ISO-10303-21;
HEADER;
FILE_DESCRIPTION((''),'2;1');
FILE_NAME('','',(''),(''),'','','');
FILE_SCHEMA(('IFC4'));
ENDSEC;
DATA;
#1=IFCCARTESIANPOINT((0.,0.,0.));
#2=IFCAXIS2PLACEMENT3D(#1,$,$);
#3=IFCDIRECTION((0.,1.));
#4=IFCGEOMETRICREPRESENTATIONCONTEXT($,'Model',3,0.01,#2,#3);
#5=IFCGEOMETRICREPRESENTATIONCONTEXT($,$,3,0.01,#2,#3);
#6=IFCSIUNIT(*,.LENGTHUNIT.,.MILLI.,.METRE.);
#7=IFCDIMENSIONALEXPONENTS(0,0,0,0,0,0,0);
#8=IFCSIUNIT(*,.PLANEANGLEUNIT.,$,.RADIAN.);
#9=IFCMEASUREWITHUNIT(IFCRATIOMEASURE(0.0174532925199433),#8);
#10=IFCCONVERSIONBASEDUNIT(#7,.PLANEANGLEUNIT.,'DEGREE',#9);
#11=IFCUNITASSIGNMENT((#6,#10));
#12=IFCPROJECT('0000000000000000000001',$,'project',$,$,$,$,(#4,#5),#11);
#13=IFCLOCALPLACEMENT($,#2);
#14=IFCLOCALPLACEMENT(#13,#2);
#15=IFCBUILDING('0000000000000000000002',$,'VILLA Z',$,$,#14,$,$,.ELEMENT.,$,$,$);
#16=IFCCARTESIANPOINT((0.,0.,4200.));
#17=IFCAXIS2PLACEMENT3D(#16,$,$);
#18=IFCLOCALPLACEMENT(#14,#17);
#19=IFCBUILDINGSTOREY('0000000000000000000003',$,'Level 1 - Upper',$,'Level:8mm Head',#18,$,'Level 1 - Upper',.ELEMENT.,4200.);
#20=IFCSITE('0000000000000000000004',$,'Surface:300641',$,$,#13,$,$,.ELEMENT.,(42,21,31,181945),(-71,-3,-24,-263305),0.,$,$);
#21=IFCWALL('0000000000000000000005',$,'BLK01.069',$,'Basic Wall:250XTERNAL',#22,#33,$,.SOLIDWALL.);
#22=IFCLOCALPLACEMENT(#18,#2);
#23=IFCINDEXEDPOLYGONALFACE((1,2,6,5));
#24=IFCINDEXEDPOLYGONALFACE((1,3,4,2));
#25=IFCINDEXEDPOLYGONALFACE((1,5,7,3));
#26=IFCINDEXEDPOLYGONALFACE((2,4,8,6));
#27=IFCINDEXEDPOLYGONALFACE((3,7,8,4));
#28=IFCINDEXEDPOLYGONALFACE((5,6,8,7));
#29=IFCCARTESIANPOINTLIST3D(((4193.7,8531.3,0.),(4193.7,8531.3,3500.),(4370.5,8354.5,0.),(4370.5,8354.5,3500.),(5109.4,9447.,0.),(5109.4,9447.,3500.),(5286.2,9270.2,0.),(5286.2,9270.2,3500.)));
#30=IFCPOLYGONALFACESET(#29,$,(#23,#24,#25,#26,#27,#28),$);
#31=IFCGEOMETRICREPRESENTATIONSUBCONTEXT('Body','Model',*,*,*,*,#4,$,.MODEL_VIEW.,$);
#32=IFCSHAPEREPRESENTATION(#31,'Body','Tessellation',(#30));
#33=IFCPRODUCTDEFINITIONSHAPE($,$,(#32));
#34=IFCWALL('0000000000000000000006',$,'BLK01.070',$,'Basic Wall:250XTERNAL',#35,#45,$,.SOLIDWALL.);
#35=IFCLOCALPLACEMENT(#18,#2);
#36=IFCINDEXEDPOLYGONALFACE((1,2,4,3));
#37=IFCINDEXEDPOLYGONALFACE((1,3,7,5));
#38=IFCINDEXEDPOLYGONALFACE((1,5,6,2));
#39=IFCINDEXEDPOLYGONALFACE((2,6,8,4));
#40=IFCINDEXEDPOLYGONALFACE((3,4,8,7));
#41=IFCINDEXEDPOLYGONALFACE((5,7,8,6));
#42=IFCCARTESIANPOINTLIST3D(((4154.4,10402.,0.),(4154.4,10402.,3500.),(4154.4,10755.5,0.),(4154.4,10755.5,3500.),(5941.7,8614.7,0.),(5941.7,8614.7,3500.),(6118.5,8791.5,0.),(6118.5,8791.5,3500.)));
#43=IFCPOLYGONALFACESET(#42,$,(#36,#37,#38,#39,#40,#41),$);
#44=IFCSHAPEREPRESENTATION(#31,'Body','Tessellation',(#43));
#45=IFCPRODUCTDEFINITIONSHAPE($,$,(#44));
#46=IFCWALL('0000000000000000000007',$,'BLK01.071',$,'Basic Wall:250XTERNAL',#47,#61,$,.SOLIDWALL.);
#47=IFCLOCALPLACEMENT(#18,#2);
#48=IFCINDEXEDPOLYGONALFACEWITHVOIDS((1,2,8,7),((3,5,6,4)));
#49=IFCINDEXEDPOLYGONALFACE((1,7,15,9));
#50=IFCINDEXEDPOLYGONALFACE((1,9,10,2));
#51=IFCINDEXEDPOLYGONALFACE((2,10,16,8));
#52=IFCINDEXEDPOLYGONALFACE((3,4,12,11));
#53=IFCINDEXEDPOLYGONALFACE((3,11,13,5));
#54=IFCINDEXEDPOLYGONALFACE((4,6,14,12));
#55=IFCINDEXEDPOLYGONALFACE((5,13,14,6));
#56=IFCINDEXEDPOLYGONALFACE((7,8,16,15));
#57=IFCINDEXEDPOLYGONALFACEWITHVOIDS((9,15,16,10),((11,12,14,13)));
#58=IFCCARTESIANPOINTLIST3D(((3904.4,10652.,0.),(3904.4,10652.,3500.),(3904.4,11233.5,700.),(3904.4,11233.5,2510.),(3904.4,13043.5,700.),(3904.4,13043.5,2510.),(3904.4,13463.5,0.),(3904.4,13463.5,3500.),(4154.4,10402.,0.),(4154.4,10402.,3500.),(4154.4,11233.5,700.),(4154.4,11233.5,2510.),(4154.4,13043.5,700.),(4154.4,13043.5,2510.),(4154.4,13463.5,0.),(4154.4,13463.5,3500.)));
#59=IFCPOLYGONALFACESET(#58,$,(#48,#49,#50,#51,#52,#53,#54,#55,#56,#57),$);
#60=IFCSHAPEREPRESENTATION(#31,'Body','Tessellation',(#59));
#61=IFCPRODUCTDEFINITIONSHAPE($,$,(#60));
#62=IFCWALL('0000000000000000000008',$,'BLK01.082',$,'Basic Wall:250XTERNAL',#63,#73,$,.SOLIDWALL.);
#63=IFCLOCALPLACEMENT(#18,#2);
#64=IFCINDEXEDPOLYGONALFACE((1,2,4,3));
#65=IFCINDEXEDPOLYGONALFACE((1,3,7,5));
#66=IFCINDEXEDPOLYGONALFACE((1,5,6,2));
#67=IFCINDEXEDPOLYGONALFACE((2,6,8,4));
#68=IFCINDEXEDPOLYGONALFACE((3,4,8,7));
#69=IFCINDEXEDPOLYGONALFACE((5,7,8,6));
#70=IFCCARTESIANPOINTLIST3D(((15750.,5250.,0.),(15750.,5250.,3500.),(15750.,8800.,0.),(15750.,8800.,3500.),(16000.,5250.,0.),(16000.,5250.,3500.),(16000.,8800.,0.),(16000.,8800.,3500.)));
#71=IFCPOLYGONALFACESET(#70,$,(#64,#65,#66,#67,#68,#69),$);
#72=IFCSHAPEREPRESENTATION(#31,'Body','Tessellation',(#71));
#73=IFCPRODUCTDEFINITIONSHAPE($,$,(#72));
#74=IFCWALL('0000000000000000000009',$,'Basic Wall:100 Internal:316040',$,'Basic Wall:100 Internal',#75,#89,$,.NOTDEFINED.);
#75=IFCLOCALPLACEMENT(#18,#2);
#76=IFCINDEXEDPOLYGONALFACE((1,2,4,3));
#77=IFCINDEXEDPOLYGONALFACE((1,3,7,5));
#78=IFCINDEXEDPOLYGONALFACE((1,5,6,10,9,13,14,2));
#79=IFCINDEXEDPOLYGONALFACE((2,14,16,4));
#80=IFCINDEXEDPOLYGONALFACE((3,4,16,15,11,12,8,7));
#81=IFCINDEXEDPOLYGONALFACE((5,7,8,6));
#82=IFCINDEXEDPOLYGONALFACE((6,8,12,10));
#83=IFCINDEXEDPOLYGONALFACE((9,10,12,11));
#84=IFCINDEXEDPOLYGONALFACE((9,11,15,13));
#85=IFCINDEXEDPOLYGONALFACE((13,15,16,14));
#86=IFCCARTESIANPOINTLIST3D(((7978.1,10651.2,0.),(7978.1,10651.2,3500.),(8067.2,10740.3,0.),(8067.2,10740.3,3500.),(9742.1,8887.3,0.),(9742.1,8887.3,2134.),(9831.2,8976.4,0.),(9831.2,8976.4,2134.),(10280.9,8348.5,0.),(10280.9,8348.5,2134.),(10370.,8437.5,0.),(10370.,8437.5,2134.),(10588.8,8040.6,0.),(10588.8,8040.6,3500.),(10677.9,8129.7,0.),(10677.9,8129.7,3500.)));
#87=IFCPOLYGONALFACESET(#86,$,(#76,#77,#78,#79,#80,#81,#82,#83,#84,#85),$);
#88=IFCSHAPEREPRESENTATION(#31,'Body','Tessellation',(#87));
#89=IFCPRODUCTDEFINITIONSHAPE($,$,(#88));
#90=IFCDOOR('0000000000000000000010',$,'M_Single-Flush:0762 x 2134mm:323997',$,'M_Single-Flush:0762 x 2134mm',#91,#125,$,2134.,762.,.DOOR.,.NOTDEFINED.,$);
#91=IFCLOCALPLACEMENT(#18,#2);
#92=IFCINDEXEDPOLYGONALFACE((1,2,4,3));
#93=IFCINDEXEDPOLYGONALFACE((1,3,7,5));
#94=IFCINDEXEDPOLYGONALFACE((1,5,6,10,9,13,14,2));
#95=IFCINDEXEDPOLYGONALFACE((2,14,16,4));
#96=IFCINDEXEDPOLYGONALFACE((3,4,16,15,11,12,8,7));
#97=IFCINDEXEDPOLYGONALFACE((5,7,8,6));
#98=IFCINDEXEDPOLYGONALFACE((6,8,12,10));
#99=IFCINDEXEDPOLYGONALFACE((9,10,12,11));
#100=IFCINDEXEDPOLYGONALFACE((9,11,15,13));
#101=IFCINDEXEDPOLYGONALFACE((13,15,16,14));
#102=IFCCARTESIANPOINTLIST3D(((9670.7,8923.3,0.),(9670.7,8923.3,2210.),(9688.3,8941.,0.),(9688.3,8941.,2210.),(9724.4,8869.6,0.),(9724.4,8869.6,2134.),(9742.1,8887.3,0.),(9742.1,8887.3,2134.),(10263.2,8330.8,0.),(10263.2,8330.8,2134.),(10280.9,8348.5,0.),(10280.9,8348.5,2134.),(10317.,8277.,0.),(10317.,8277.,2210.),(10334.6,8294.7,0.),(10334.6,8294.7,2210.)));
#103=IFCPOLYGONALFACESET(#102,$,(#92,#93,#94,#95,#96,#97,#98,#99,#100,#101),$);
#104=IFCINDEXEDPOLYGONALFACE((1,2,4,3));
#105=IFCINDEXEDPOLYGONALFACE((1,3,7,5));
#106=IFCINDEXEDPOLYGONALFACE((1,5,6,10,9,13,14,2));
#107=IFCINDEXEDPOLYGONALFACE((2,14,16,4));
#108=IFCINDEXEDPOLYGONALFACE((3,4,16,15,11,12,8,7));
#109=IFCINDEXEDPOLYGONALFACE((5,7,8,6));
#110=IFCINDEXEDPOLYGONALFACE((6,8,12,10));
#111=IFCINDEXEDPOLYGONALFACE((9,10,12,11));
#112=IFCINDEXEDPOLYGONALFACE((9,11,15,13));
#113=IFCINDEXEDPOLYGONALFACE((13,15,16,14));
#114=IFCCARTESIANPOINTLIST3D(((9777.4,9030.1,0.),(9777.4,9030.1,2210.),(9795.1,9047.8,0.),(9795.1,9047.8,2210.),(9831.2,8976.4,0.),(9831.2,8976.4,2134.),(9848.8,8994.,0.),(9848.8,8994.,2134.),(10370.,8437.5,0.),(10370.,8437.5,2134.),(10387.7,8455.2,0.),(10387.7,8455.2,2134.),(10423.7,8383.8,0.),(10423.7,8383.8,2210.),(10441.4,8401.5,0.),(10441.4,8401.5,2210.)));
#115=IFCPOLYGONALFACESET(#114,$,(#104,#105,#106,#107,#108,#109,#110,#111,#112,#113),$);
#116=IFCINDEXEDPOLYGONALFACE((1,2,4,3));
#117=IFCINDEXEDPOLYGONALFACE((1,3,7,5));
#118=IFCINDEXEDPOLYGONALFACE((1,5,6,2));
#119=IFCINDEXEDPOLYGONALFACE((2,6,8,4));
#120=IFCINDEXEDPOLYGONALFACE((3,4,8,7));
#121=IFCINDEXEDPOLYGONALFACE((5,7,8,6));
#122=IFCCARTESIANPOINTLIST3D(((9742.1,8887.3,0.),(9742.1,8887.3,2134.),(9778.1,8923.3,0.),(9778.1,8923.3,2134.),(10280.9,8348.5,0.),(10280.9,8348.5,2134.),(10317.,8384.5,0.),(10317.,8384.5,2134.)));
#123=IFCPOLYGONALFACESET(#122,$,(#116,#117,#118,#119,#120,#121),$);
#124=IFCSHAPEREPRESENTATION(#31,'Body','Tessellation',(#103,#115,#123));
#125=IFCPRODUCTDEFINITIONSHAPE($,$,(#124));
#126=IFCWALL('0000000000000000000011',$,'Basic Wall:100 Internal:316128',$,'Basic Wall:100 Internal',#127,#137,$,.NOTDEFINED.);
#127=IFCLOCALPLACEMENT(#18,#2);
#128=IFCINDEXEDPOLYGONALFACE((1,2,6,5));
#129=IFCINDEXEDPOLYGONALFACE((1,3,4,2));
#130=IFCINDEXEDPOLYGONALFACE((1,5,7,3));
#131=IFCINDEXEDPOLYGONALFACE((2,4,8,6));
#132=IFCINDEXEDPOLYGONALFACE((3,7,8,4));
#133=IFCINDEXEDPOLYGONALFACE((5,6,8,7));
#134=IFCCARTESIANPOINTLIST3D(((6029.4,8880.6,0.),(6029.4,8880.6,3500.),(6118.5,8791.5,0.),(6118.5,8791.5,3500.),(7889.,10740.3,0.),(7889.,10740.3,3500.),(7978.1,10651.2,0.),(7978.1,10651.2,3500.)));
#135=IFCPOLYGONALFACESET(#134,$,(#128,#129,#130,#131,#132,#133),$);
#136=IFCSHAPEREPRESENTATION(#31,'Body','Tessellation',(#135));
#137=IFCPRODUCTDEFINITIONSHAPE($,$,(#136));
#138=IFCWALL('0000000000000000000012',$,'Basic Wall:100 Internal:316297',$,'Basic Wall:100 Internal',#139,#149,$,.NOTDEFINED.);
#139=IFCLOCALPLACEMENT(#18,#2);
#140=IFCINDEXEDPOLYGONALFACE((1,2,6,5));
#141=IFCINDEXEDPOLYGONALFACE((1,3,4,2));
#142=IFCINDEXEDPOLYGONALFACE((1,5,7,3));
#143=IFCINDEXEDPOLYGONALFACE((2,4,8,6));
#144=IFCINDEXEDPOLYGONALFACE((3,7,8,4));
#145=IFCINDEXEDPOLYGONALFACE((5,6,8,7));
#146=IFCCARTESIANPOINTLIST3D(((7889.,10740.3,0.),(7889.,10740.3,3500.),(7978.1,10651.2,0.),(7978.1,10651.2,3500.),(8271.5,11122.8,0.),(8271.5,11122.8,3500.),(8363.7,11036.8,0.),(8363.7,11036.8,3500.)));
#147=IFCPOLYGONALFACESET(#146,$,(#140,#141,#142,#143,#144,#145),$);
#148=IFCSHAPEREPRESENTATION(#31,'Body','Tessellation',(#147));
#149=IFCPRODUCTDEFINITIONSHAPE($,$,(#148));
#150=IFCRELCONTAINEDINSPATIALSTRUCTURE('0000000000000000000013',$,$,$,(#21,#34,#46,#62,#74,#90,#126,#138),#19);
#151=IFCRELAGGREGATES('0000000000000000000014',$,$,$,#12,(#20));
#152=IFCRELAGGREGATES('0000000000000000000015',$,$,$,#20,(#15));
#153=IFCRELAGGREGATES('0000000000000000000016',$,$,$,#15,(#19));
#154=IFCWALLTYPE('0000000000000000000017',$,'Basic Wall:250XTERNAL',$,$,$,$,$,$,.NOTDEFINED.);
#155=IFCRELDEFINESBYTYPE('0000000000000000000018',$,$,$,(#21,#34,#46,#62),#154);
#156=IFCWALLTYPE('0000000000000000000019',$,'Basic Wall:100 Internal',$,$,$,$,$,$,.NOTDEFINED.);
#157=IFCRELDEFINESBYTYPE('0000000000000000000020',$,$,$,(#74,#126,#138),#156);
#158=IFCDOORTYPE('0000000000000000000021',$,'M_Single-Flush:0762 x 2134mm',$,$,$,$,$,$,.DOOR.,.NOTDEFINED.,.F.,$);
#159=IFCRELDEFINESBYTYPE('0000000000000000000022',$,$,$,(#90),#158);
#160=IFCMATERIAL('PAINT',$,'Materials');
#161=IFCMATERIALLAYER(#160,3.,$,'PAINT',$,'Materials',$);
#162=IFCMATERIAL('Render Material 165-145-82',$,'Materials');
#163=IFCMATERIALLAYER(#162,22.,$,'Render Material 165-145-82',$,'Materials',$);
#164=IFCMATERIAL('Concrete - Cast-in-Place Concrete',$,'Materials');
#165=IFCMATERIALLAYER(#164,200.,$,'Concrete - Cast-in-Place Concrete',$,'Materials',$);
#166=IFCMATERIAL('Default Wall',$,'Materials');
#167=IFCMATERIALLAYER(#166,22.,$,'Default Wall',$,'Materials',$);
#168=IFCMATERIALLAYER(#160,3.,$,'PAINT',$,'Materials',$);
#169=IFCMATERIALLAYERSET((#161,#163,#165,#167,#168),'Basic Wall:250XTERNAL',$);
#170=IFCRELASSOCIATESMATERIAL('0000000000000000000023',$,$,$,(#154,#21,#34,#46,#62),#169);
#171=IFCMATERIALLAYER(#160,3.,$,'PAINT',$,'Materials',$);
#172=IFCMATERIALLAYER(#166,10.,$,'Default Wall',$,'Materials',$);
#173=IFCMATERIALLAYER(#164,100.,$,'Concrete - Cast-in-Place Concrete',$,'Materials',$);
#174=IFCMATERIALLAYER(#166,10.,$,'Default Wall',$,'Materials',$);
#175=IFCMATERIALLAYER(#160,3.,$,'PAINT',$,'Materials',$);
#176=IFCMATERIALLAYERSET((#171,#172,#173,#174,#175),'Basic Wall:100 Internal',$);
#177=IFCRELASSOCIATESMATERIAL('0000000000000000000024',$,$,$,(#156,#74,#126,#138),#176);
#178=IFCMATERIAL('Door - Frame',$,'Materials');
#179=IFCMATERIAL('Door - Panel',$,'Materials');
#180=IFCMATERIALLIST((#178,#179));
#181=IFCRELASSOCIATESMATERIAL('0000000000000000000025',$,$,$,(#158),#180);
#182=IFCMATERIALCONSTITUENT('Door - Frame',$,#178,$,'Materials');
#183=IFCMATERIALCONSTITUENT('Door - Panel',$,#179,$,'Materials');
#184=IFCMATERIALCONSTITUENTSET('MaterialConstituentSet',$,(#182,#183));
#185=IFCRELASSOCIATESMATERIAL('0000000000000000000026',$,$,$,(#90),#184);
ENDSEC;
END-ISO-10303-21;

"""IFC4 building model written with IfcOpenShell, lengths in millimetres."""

from ifc_helpers import new_model, entity, si_unit, converted_unit, direction, frame, frame_2d, origin, place, context, subcontext, project, spatial, polyline, rectangle, outline, extrude, clip, halfspace, source, transform, mapped, material, material_list, layer, layer_set, layer_usage, constituent, constituent_set, type_object, type_shapes, element, fill, save


model = new_model("IFC4")

# Units and contexts
model_context = context("Model", 3, precision=0.01, world=origin(), true_north=direction((0.0, 1.0)))
context_of_model = context(None, 3, precision=0.01, world=origin(), true_north=direction((0.0, 1.0)))
body_context = subcontext(model_context, "Body", "Model", "MODEL_VIEW")
ifc_project = project(units=[si_unit("LENGTHUNIT", "METRE", prefix="MILLI"), converted_unit("PLANEANGLEUNIT", "DEGREE", entity("IfcRatioMeasure", 0.0174532925199433), si_unit("PLANEANGLEUNIT", "RADIAN"), dimensions=[0, 0, 0, 0, 0, 0, 0])], contexts=[model_context, context_of_model])

# Site, building, storey
site_placement = place(None, origin())
site = spatial("IfcSite", under=ifc_project, at=site_placement, Name="Surface:300641", CompositionType="ELEMENT", RefLatitude=(42, 21, 31, 181945), RefLongitude=(-71, -3, -24, -263305), RefElevation=0.0)
building_placement = place(site_placement, origin())
building = spatial("IfcBuilding", under=site, at=building_placement, Name="VILLA Z", CompositionType="ELEMENT")
storey_placement = place(building_placement, frame((0.0, 0.0, 4200.0)))
storey = spatial("IfcBuildingStorey", under=building, at=storey_placement, Name="Level 1 - Upper", ObjectType="Level:8mm Head", LongName="Level 1 - Upper", CompositionType="ELEMENT", Elevation=4200.0)

# Shared definitions
ifc_material_1 = material(Name="PAINT", Category="Materials")
ifc_layer_1 = layer(ifc_material_1, 3.0, Name="PAINT", Category="Materials")
ifc_material_2 = material(Name="Render Material 165-145-82", Category="Materials")
ifc_layer_2 = layer(ifc_material_2, 22.0, Name="Render Material 165-145-82", Category="Materials")
ifc_material_3 = material(Name="Concrete - Cast-in-Place Concrete", Category="Materials")
ifc_layer_3 = layer(ifc_material_3, 200.0, Name="Concrete - Cast-in-Place Concrete", Category="Materials")
ifc_material_4 = material(Name="Default Wall", Category="Materials")
ifc_layer_4 = layer(ifc_material_4, 22.0, Name="Default Wall", Category="Materials")
ifc_layer_5 = layer(ifc_material_1, 3.0, Name="PAINT", Category="Materials")
ifc_layer_set_1 = layer_set([ifc_layer_1, ifc_layer_2, ifc_layer_3, ifc_layer_4, ifc_layer_5], Name="Basic Wall:250XTERNAL")
wall_type_1 = type_object("IfcWallType", Name="Basic Wall:250XTERNAL", PredefinedType="NOTDEFINED", material=ifc_layer_set_1)

# Walls
ifc_layer_usage_1 = layer_usage(ifc_layer_set_1, "AXIS2", "NEGATIVE", 125.0)
wall_1_placement = place(storey_placement, frame((4282.1, 8442.9, 0.0), z_axis=(0.0, 0.0, 1.0), x_axis=(0.707107, 0.707107, 0.0)))
element("IfcWall", 1, at=wall_1_placement, inside=storey, type_object=wall_type_1, material=ifc_layer_usage_1, Name="BLK01.069", ObjectType="Basic Wall:250XTERNAL", PredefinedType="SOLIDWALL", context=body_context, shape_type="Clipping", body=[
    clip(extrude(rectangle(XDim=1295.0, YDim=250.0, at=frame_2d((647.5, 0.0), x_axis=(-1.0, 0.0))), origin(), (0.0, 0.0, 1.0), 3500.0), halfspace(origin(), True)),
])
ifc_layer_usage_2 = layer_usage(ifc_layer_set_1, "AXIS2", "NEGATIVE", 125.0)
wall_2_placement = place(storey_placement, frame((6030.1, 8703.1, 0.0), z_axis=(0.0, 0.0, 1.0), x_axis=(-0.707107, 0.707107, 0.0)))
element("IfcWall", 2, at=wall_2_placement, inside=storey, type_object=wall_type_1, material=ifc_layer_usage_2, Name="BLK01.070", ObjectType="Basic Wall:250XTERNAL", PredefinedType="SOLIDWALL", context=body_context, shape_type="Clipping", body=[
    clip(extrude(outline(polyline([(2777.5, -125.0), (2527.5, 125.0), (1177.0, 125.0), (927.0, 125.0), (0.0, 125.0), (0.0, -125.0), (126.0, -125.0), (2777.5, -125.0)])), origin(), (0.0, 0.0, 1.0), 3500.0), halfspace(origin(), True)),
])

# Wall, opening
ifc_layer_usage_3 = layer_usage(ifc_layer_set_1, "AXIS2", "NEGATIVE", 125.0)
wall_3_placement = place(storey_placement, frame((4029.4, 10402.0, 0.0), z_axis=(0.0, 0.0, 1.0), x_axis=(0.0, 1.0, 0.0)))
wall_3 = element("IfcWall", 3, at=wall_3_placement, inside=storey, type_object=wall_type_1, material=ifc_layer_usage_3, Name="BLK01.071", ObjectType="Basic Wall:250XTERNAL", PredefinedType="SOLIDWALL", context=body_context, shape_type="Clipping", body=[
    clip(extrude(outline(polyline([(3061.5, -125.0), (3061.5, 125.0), (250.0, 125.0), (0.0, -125.0), (353.6, -125.0), (2811.5, -125.0), (3061.5, -125.0)])), origin(), (0.0, 0.0, 1.0), 3500.0), halfspace(origin(), True)),
])
opening_1_placement = place(wall_3_placement, frame((831.5, -125.0, 700.0)))
element("IfcOpeningElement", 4, at=opening_1_placement, cuts=wall_3, ObjectType="Opening", PredefinedType="OPENING", context=body_context, shape_type="SweptSolid", body=[
    extrude(rectangle(XDim=1810.0, YDim=1810.0, at=frame_2d((905.0, 905.0), x_axis=(-1.0, 0.0))), frame((0.0, 0.0, 0.0), z_axis=(0.0, 1.0, 0.0), x_axis=(0.0, 0.0, 1.0)), (0.0, 0.0, 1.0), 250.0),
])

# Wall
ifc_layer_usage_4 = layer_usage(ifc_layer_set_1, "AXIS2", "POSITIVE", -125.0)
wall_4_placement = place(storey_placement, frame((15875.0, 5250.0, 0.0), z_axis=(0.0, 0.0, 1.0), x_axis=(0.0, 1.0, 0.0)))
element("IfcWall", 5, at=wall_4_placement, inside=storey, type_object=wall_type_1, material=ifc_layer_usage_4, Name="BLK01.082", ObjectType="Basic Wall:250XTERNAL", PredefinedType="SOLIDWALL", context=body_context, shape_type="Clipping", body=[
    clip(extrude(rectangle(XDim=3550.0, YDim=250.0, at=frame_2d((1775.0, 0.0), x_axis=(-1.0, 0.0))), origin(), (0.0, 0.0, 1.0), 3500.0), halfspace(origin(), True)),
])
ifc_layer_6 = layer(ifc_material_1, 3.0, Name="PAINT", Category="Materials")
ifc_layer_7 = layer(ifc_material_4, 10.0, Name="Default Wall", Category="Materials")
ifc_layer_8 = layer(ifc_material_3, 100.0, Name="Concrete - Cast-in-Place Concrete", Category="Materials")
ifc_layer_9 = layer(ifc_material_4, 10.0, Name="Default Wall", Category="Materials")
ifc_layer_10 = layer(ifc_material_1, 3.0, Name="PAINT", Category="Materials")
ifc_layer_set_2 = layer_set([ifc_layer_6, ifc_layer_7, ifc_layer_8, ifc_layer_9, ifc_layer_10], Name="Basic Wall:100 Internal")
wall_type_2 = type_object("IfcWallType", Name="Basic Wall:100 Internal", PredefinedType="NOTDEFINED", material=ifc_layer_set_2)

# Wall, opening, door
ifc_layer_usage_5 = layer_usage(ifc_layer_set_2, "AXIS2", "POSITIVE", -63.0)
wall_5_placement = place(storey_placement, frame((8022.7, 10695.7, 0.0), z_axis=(0.0, 0.0, 1.0), x_axis=(0.707107, -0.707107, 0.0)))
wall_5 = element("IfcWall", 6, at=wall_5_placement, inside=storey, type_object=wall_type_2, material=ifc_layer_usage_5, Name="Basic Wall:100 Internal:316040", ObjectType="Basic Wall:100 Internal", PredefinedType="NOTDEFINED", context=body_context, shape_type="Clipping", body=[
    clip(extrude(rectangle(XDim=3692.0, YDim=126.0, at=frame_2d((1846.0, 0.0), x_axis=(-1.0, 0.0))), origin(), (0.0, 0.0, 1.0), 3500.0), halfspace(origin(), True)),
])
opening_2_placement = place(wall_5_placement, frame((3256.6, 63.0, 0.0)))
opening_2 = element("IfcOpeningElement", 7, at=opening_2_placement, cuts=wall_5, ObjectType="Opening", PredefinedType="OPENING", context=body_context, shape_type="SweptSolid", body=[
    extrude(rectangle(XDim=762.0, YDim=2134.0, at=frame_2d((1067.0, 381.0), x_axis=(0.0, -1.0))), frame((0.0, 0.0, 0.0), z_axis=(0.0, -1.0, 0.0), x_axis=(0.0, 0.0, 1.0)), (0.0, 0.0, 1.0), 126.0),
])
ifc_material_5 = material(Name="Door - Frame", Category="Materials")
ifc_constituent_1 = constituent(ifc_material_5, Name="Door - Frame", Category="Materials")
ifc_material_6 = material(Name="Door - Panel", Category="Materials")
ifc_constituent_2 = constituent(ifc_material_6, Name="Door - Panel", Category="Materials")
ifc_constituent_set_1 = constituent_set(constituents=[ifc_constituent_1, ifc_constituent_2], Name="MaterialConstituentSet")
ifc_material_list = material_list([ifc_material_5, ifc_material_6])
door_type = type_object("IfcDoorType", Name="M_Single-Flush:0762 x 2134mm", OperationType="NOTDEFINED", ParameterTakesPrecedence=False, PredefinedType="DOOR", material=ifc_material_list)
shared_shape_1 = source(origin(), body_context, "Body", "SweptSolid", [
    extrude(outline(polyline([(-457.0, -1124.0), (457.0, -1124.0), (457.0, 1086.0), (381.0, 1086.0), (381.0, -1048.0), (-381.0, -1048.0), (-381.0, 1086.0), (-457.0, 1086.0), (-457.0, -1124.0)])), frame((381.0, 151.0, 1086.0), z_axis=(0.0, -1.0, 0.0), x_axis=(-1.0, 0.0, 0.0)), (0.0, 0.0, 1.0), 25.0),
    extrude(outline(polyline([(-1124.0, -457.0), (1086.0, -457.0), (1086.0, -381.0), (-1048.0, -381.0), (-1048.0, 381.0), (1086.0, 381.0), (1086.0, 457.0), (-1124.0, 457.0), (-1124.0, -457.0)])), frame((381.0, 0.0, 1086.0), z_axis=(0.0, -1.0, 0.0), x_axis=(0.0, 0.0, -1.0)), (0.0, 0.0, 1.0), 25.0),
    extrude(rectangle(XDim=762.0, YDim=51.0, at=frame_2d((0.0, 0.0), x_axis=(1.0, 0.0))), frame((381.0, 100.5, 0.0)), (0.0, 0.0, 1.0), 2134.0),
])
type_shapes(door_type, [shared_shape_1])
door_1_placement = place(opening_2_placement, frame((0.0, 0.0, 0.0), z_axis=(0.0, 0.0, 1.0), x_axis=(-1.0, 0.0, 0.0)))
door_1 = element("IfcDoor", 8, at=door_1_placement, inside=storey, type_object=door_type, material=ifc_constituent_set_1, Name="M_Single-Flush:0762 x 2134mm:323997", ObjectType="M_Single-Flush:0762 x 2134mm", OperationType="NOTDEFINED", OverallHeight=2134.0, OverallWidth=762.0, PredefinedType="DOOR", context=body_context, shape_type="MappedRepresentation", body=[
    mapped(shared_shape_1, transform((0.0, 0.0, 0.0), scale=1.0)),
])
fill(opening_2, door_1)

# Walls
ifc_layer_usage_6 = layer_usage(ifc_layer_set_2, "AXIS2", "NEGATIVE", 63.0)
wall_6_placement = place(storey_placement, frame((6073.9, 8836.1, 0.0), z_axis=(0.0, 0.0, 1.0), x_axis=(0.707107, 0.707107, 0.0)))
element("IfcWall", 9, at=wall_6_placement, inside=storey, type_object=wall_type_2, material=ifc_layer_usage_6, Name="Basic Wall:100 Internal:316128", ObjectType="Basic Wall:100 Internal", PredefinedType="NOTDEFINED", context=body_context, shape_type="Clipping", body=[
    clip(extrude(rectangle(XDim=2630.0, YDim=126.0, at=frame_2d((1315.0, 0.0), x_axis=(-1.0, 0.0))), origin(), (0.0, 0.0, 1.0), 3500.0), halfspace(origin(), True)),
])
ifc_layer_usage_7 = layer_usage(ifc_layer_set_2, "AXIS2", "NEGATIVE", 63.0)
wall_7_placement = place(storey_placement, frame((7933.6, 10695.7, 0.0), z_axis=(0.0, 0.0, 1.0), x_axis=(0.707107, 0.707107, 0.0)))
element("IfcWall", 10, at=wall_7_placement, inside=storey, type_object=wall_type_2, material=ifc_layer_usage_7, Name="Basic Wall:100 Internal:316297", ObjectType="Basic Wall:100 Internal", PredefinedType="NOTDEFINED", context=body_context, shape_type="Clipping", body=[
    clip(extrude(outline(polyline([(545.3, -63.0), (540.9, 63.0), (0.0, 63.0), (0.0, -63.0), (126.0, -63.0), (419.2, -63.0), (545.3, -63.0)])), origin(), (0.0, 0.0, 1.0), 3500.0), halfspace(origin(), True)),
])

save(model, "model.ifc")
